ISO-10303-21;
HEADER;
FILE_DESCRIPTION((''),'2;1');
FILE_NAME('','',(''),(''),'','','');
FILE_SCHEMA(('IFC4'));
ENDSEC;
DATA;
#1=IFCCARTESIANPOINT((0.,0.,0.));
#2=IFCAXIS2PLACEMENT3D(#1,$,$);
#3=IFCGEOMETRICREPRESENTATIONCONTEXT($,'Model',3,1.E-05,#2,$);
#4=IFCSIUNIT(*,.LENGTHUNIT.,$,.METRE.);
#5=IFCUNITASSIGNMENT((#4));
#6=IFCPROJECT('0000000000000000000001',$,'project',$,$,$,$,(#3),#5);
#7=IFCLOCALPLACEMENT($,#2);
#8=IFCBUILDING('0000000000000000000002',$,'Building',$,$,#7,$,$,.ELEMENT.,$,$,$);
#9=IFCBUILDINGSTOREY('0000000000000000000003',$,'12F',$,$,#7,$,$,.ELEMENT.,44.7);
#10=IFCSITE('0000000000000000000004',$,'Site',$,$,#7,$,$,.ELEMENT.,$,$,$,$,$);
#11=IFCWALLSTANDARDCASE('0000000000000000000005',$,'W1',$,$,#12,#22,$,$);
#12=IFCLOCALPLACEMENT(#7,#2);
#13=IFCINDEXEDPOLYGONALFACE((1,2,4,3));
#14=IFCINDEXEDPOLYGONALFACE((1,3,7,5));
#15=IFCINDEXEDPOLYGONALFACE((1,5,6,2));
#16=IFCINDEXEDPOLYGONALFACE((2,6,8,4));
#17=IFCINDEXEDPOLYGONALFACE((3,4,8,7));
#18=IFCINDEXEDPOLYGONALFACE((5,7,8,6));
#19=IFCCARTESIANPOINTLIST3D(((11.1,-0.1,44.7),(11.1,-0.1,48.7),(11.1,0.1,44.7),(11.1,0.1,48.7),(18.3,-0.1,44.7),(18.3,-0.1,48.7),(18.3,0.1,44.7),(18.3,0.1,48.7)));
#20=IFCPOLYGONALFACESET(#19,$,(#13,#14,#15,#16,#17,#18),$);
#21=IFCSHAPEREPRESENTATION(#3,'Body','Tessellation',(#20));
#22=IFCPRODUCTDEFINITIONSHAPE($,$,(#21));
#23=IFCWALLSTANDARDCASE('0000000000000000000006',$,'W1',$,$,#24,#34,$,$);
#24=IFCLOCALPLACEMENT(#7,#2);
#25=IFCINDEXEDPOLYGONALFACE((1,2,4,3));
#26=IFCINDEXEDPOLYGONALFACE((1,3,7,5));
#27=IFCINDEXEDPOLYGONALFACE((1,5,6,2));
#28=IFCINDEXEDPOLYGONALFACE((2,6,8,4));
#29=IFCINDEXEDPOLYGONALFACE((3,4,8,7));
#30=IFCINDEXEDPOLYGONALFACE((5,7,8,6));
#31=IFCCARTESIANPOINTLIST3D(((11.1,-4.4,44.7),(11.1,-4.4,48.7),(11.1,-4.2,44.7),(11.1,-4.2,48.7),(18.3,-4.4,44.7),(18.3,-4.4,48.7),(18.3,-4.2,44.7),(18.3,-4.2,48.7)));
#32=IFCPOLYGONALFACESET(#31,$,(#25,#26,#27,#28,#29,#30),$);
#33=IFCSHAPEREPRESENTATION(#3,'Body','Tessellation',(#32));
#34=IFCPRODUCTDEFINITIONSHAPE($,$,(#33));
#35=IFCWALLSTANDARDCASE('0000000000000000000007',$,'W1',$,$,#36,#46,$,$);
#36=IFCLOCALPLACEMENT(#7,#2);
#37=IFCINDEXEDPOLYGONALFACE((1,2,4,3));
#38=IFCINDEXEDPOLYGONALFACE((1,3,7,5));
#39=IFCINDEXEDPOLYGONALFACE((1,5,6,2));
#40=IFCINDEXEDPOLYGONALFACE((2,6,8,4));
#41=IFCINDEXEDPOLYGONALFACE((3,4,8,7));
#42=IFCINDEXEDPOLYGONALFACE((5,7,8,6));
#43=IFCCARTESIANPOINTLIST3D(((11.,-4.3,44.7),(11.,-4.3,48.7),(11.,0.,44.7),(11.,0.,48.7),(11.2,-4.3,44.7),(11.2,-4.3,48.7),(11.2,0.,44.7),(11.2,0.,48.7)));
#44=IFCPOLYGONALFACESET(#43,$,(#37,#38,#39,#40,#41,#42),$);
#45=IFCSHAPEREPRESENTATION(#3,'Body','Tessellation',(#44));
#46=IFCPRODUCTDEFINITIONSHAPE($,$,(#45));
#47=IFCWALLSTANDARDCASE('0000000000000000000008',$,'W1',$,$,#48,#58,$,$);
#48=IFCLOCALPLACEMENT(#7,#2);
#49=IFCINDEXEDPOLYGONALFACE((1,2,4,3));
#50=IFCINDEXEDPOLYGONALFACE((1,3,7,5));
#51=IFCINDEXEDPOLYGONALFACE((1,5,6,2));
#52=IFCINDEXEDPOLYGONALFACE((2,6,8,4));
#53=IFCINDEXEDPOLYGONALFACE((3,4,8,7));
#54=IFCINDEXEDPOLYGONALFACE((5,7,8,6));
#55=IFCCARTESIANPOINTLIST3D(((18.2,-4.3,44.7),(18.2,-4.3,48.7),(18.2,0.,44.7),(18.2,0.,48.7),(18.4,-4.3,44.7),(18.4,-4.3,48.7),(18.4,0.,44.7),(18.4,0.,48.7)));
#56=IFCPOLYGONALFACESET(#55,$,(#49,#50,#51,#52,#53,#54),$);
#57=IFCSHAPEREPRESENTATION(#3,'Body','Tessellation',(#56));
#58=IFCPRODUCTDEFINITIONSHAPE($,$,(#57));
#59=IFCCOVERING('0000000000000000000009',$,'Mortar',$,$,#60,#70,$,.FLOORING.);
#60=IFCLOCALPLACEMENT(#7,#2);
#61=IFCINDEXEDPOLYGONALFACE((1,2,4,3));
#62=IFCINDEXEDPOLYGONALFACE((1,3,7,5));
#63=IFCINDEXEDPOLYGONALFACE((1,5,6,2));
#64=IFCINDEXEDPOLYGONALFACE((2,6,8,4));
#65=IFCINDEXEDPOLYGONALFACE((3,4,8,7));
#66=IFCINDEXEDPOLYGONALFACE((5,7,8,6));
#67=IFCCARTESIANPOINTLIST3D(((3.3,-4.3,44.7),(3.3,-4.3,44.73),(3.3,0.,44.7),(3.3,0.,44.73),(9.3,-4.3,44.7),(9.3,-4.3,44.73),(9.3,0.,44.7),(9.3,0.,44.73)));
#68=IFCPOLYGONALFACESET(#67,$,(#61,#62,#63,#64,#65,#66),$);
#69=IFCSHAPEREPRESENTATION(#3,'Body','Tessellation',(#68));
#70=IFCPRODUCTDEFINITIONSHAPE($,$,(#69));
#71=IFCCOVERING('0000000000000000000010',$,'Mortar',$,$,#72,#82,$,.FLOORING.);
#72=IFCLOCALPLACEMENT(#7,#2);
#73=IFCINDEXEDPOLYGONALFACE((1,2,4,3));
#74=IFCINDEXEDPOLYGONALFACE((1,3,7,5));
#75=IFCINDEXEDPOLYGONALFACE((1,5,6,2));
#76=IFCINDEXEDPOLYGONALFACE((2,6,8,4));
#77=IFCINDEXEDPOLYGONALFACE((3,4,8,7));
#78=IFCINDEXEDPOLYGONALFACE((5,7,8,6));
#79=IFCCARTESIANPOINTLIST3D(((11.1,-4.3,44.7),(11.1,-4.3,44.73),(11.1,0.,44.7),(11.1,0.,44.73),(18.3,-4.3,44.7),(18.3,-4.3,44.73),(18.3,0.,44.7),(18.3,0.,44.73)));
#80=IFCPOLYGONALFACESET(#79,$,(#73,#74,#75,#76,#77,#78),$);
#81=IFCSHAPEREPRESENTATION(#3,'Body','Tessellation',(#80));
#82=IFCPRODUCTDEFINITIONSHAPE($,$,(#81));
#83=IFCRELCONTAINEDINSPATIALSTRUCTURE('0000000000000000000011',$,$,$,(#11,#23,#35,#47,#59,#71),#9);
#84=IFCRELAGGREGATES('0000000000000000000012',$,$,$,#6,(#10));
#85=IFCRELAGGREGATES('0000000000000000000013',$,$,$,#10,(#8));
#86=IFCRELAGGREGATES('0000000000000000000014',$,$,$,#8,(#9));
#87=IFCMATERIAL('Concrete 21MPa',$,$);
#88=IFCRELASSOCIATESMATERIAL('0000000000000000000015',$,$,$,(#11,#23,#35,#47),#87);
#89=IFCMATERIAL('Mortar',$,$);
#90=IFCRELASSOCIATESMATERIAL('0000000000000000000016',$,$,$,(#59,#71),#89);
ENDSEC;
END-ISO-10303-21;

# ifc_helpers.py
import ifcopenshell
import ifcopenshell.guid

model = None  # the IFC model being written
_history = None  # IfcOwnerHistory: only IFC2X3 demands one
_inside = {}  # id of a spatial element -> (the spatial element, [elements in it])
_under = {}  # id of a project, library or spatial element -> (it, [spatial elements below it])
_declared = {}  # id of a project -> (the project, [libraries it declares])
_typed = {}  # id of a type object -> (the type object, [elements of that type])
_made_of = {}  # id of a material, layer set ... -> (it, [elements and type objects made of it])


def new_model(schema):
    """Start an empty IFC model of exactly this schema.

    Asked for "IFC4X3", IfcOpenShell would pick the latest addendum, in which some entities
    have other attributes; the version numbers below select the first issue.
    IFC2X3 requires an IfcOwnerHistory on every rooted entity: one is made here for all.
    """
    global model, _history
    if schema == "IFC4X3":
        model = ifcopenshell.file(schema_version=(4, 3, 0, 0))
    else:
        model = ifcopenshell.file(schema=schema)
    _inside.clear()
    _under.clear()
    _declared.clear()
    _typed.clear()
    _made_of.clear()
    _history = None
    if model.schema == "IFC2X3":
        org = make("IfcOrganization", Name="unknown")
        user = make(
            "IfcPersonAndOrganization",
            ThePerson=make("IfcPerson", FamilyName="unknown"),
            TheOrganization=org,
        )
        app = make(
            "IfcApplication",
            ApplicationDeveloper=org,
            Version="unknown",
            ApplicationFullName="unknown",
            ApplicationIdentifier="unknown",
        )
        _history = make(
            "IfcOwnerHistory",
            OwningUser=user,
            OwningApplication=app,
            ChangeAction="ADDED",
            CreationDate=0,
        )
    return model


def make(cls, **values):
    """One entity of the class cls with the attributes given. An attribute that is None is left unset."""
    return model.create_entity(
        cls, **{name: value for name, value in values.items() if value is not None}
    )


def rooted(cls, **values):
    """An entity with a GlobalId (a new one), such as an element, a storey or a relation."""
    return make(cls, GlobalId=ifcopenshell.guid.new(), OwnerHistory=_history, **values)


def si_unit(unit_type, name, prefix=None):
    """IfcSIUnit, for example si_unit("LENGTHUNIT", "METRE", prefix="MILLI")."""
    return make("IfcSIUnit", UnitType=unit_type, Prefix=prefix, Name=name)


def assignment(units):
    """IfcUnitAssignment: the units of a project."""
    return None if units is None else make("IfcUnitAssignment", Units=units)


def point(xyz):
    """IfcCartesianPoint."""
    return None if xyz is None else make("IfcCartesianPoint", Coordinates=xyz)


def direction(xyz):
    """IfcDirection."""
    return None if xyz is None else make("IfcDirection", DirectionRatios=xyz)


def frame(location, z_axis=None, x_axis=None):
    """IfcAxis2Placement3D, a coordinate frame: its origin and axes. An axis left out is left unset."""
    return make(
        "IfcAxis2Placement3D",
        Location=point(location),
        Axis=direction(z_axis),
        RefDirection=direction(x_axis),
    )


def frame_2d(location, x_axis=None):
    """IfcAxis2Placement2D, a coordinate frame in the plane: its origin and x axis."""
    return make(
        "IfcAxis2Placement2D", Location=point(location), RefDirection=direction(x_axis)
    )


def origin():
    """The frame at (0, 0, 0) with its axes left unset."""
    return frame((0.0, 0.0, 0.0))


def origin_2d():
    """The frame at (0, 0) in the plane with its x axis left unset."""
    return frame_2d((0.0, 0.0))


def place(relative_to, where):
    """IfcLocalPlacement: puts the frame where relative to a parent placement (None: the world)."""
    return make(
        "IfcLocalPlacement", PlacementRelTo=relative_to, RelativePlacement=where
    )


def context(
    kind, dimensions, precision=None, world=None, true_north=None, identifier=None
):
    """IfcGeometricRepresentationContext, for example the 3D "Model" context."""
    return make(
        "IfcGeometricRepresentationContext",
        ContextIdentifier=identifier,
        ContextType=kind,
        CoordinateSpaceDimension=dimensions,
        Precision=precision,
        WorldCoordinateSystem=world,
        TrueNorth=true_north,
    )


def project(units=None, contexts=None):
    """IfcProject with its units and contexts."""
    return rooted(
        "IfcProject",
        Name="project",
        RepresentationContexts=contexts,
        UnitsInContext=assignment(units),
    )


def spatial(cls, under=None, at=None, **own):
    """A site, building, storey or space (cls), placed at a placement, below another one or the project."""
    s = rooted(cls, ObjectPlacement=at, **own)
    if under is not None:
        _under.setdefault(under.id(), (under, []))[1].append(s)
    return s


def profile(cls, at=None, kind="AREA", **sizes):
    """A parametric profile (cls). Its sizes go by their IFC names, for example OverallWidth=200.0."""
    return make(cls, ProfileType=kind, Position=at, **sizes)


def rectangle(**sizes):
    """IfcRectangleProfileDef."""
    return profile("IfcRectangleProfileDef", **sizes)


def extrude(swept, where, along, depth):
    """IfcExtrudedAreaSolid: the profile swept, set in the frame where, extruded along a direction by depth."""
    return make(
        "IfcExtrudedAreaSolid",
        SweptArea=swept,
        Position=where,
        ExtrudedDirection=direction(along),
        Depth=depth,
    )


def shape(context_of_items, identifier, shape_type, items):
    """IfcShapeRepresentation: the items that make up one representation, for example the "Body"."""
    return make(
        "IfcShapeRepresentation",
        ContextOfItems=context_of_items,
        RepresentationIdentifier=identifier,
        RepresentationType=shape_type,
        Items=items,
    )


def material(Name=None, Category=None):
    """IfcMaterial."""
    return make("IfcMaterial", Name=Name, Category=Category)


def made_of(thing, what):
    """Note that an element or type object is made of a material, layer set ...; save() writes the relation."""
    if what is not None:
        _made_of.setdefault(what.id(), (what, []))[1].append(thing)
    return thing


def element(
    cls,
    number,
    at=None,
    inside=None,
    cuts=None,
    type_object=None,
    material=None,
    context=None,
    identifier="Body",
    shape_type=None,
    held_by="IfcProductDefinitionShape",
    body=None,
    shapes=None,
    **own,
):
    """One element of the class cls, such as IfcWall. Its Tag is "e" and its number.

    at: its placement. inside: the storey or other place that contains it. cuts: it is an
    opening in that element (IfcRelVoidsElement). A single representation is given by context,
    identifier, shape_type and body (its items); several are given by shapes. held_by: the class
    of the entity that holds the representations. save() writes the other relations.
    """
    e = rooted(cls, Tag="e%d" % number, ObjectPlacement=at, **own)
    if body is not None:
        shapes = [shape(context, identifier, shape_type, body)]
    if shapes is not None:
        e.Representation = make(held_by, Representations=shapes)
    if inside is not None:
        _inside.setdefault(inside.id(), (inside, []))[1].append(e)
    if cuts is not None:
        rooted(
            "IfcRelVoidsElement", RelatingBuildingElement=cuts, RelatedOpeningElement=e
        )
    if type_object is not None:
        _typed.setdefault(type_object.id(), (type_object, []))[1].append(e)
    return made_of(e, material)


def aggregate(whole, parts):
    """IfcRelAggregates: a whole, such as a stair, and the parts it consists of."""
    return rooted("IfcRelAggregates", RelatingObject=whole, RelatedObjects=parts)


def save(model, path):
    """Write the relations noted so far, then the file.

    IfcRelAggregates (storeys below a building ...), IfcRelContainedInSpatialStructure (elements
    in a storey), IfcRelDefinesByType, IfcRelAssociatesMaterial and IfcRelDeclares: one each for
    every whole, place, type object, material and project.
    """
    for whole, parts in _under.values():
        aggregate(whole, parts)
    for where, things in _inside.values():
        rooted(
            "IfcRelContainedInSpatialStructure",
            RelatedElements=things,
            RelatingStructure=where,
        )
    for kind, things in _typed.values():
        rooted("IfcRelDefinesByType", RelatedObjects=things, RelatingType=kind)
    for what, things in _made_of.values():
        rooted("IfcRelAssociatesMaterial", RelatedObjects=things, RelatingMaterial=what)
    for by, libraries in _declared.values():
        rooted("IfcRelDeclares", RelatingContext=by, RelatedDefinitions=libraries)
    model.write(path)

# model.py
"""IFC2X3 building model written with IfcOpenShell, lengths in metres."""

from ifc_helpers import new_model, si_unit, frame, origin, origin_2d, place, context, project, spatial, rectangle, extrude, material, element, save


model = new_model("IFC2X3")

# Units and contexts
model_context = context("Model", 3, precision=1e-05, world=origin())
ifc_project = project(units=[si_unit("LENGTHUNIT", "METRE")], contexts=[model_context])

# Site, building, storey
placement = place(None, origin())
site = spatial("IfcSite", under=ifc_project, at=placement, Name="Site", CompositionType="ELEMENT")
building = spatial("IfcBuilding", under=site, at=placement, Name="Building", CompositionType="ELEMENT")
storey = spatial("IfcBuildingStorey", under=building, at=placement, Name="12F", CompositionType="ELEMENT", Elevation=44.7)

# Shared definitions
ifc_material_1 = material(Name="Concrete 21MPa")

# Walls
for number, where, name in (
    (1, (14.7, 0.0, 44.7), "W1"),
    (2, (14.7, -4.3, 44.7), "W1"),
):
    element("IfcWallStandardCase", number, at=place(None, frame(where)), inside=storey, material=ifc_material_1, Name=name, context=model_context, shape_type="SweptSolid", body=[
        extrude(rectangle(XDim=7.2, YDim=0.2, at=origin_2d()), origin(), (0.0, 0.0, 1.0), 4.0),
    ])
for number, where, name in (
    (3, (11.1, -2.15, 44.7), "W1"),
    (4, (18.3, -2.15, 44.7), "W1"),
):
    element("IfcWallStandardCase", number, at=place(None, frame(where)), inside=storey, material=ifc_material_1, Name=name, context=model_context, shape_type="SweptSolid", body=[
        extrude(rectangle(XDim=0.2, YDim=4.3, at=origin_2d()), origin(), (0.0, 0.0, 1.0), 4.0),
    ])

# Coverings
ifc_material_2 = material(Name="Mortar")
covering_1_placement = place(None, frame((6.3, -2.15, 44.7)))
element("IfcCovering", 5, at=covering_1_placement, inside=storey, material=ifc_material_2, Name="Mortar", PredefinedType="FLOORING", context=model_context, shape_type="SweptSolid", body=[
    extrude(rectangle(XDim=6.0, YDim=4.3, at=origin_2d()), origin(), (0.0, 0.0, 1.0), 0.03),
])
covering_2_placement = place(None, frame((14.7, -2.15, 44.7)))
element("IfcCovering", 6, at=covering_2_placement, inside=storey, material=ifc_material_2, Name="Mortar", PredefinedType="FLOORING", context=model_context, shape_type="SweptSolid", body=[
    extrude(rectangle(XDim=7.2, YDim=4.3, at=origin_2d()), origin(), (0.0, 0.0, 1.0), 0.03),
])

save(model, "model.ifc")
